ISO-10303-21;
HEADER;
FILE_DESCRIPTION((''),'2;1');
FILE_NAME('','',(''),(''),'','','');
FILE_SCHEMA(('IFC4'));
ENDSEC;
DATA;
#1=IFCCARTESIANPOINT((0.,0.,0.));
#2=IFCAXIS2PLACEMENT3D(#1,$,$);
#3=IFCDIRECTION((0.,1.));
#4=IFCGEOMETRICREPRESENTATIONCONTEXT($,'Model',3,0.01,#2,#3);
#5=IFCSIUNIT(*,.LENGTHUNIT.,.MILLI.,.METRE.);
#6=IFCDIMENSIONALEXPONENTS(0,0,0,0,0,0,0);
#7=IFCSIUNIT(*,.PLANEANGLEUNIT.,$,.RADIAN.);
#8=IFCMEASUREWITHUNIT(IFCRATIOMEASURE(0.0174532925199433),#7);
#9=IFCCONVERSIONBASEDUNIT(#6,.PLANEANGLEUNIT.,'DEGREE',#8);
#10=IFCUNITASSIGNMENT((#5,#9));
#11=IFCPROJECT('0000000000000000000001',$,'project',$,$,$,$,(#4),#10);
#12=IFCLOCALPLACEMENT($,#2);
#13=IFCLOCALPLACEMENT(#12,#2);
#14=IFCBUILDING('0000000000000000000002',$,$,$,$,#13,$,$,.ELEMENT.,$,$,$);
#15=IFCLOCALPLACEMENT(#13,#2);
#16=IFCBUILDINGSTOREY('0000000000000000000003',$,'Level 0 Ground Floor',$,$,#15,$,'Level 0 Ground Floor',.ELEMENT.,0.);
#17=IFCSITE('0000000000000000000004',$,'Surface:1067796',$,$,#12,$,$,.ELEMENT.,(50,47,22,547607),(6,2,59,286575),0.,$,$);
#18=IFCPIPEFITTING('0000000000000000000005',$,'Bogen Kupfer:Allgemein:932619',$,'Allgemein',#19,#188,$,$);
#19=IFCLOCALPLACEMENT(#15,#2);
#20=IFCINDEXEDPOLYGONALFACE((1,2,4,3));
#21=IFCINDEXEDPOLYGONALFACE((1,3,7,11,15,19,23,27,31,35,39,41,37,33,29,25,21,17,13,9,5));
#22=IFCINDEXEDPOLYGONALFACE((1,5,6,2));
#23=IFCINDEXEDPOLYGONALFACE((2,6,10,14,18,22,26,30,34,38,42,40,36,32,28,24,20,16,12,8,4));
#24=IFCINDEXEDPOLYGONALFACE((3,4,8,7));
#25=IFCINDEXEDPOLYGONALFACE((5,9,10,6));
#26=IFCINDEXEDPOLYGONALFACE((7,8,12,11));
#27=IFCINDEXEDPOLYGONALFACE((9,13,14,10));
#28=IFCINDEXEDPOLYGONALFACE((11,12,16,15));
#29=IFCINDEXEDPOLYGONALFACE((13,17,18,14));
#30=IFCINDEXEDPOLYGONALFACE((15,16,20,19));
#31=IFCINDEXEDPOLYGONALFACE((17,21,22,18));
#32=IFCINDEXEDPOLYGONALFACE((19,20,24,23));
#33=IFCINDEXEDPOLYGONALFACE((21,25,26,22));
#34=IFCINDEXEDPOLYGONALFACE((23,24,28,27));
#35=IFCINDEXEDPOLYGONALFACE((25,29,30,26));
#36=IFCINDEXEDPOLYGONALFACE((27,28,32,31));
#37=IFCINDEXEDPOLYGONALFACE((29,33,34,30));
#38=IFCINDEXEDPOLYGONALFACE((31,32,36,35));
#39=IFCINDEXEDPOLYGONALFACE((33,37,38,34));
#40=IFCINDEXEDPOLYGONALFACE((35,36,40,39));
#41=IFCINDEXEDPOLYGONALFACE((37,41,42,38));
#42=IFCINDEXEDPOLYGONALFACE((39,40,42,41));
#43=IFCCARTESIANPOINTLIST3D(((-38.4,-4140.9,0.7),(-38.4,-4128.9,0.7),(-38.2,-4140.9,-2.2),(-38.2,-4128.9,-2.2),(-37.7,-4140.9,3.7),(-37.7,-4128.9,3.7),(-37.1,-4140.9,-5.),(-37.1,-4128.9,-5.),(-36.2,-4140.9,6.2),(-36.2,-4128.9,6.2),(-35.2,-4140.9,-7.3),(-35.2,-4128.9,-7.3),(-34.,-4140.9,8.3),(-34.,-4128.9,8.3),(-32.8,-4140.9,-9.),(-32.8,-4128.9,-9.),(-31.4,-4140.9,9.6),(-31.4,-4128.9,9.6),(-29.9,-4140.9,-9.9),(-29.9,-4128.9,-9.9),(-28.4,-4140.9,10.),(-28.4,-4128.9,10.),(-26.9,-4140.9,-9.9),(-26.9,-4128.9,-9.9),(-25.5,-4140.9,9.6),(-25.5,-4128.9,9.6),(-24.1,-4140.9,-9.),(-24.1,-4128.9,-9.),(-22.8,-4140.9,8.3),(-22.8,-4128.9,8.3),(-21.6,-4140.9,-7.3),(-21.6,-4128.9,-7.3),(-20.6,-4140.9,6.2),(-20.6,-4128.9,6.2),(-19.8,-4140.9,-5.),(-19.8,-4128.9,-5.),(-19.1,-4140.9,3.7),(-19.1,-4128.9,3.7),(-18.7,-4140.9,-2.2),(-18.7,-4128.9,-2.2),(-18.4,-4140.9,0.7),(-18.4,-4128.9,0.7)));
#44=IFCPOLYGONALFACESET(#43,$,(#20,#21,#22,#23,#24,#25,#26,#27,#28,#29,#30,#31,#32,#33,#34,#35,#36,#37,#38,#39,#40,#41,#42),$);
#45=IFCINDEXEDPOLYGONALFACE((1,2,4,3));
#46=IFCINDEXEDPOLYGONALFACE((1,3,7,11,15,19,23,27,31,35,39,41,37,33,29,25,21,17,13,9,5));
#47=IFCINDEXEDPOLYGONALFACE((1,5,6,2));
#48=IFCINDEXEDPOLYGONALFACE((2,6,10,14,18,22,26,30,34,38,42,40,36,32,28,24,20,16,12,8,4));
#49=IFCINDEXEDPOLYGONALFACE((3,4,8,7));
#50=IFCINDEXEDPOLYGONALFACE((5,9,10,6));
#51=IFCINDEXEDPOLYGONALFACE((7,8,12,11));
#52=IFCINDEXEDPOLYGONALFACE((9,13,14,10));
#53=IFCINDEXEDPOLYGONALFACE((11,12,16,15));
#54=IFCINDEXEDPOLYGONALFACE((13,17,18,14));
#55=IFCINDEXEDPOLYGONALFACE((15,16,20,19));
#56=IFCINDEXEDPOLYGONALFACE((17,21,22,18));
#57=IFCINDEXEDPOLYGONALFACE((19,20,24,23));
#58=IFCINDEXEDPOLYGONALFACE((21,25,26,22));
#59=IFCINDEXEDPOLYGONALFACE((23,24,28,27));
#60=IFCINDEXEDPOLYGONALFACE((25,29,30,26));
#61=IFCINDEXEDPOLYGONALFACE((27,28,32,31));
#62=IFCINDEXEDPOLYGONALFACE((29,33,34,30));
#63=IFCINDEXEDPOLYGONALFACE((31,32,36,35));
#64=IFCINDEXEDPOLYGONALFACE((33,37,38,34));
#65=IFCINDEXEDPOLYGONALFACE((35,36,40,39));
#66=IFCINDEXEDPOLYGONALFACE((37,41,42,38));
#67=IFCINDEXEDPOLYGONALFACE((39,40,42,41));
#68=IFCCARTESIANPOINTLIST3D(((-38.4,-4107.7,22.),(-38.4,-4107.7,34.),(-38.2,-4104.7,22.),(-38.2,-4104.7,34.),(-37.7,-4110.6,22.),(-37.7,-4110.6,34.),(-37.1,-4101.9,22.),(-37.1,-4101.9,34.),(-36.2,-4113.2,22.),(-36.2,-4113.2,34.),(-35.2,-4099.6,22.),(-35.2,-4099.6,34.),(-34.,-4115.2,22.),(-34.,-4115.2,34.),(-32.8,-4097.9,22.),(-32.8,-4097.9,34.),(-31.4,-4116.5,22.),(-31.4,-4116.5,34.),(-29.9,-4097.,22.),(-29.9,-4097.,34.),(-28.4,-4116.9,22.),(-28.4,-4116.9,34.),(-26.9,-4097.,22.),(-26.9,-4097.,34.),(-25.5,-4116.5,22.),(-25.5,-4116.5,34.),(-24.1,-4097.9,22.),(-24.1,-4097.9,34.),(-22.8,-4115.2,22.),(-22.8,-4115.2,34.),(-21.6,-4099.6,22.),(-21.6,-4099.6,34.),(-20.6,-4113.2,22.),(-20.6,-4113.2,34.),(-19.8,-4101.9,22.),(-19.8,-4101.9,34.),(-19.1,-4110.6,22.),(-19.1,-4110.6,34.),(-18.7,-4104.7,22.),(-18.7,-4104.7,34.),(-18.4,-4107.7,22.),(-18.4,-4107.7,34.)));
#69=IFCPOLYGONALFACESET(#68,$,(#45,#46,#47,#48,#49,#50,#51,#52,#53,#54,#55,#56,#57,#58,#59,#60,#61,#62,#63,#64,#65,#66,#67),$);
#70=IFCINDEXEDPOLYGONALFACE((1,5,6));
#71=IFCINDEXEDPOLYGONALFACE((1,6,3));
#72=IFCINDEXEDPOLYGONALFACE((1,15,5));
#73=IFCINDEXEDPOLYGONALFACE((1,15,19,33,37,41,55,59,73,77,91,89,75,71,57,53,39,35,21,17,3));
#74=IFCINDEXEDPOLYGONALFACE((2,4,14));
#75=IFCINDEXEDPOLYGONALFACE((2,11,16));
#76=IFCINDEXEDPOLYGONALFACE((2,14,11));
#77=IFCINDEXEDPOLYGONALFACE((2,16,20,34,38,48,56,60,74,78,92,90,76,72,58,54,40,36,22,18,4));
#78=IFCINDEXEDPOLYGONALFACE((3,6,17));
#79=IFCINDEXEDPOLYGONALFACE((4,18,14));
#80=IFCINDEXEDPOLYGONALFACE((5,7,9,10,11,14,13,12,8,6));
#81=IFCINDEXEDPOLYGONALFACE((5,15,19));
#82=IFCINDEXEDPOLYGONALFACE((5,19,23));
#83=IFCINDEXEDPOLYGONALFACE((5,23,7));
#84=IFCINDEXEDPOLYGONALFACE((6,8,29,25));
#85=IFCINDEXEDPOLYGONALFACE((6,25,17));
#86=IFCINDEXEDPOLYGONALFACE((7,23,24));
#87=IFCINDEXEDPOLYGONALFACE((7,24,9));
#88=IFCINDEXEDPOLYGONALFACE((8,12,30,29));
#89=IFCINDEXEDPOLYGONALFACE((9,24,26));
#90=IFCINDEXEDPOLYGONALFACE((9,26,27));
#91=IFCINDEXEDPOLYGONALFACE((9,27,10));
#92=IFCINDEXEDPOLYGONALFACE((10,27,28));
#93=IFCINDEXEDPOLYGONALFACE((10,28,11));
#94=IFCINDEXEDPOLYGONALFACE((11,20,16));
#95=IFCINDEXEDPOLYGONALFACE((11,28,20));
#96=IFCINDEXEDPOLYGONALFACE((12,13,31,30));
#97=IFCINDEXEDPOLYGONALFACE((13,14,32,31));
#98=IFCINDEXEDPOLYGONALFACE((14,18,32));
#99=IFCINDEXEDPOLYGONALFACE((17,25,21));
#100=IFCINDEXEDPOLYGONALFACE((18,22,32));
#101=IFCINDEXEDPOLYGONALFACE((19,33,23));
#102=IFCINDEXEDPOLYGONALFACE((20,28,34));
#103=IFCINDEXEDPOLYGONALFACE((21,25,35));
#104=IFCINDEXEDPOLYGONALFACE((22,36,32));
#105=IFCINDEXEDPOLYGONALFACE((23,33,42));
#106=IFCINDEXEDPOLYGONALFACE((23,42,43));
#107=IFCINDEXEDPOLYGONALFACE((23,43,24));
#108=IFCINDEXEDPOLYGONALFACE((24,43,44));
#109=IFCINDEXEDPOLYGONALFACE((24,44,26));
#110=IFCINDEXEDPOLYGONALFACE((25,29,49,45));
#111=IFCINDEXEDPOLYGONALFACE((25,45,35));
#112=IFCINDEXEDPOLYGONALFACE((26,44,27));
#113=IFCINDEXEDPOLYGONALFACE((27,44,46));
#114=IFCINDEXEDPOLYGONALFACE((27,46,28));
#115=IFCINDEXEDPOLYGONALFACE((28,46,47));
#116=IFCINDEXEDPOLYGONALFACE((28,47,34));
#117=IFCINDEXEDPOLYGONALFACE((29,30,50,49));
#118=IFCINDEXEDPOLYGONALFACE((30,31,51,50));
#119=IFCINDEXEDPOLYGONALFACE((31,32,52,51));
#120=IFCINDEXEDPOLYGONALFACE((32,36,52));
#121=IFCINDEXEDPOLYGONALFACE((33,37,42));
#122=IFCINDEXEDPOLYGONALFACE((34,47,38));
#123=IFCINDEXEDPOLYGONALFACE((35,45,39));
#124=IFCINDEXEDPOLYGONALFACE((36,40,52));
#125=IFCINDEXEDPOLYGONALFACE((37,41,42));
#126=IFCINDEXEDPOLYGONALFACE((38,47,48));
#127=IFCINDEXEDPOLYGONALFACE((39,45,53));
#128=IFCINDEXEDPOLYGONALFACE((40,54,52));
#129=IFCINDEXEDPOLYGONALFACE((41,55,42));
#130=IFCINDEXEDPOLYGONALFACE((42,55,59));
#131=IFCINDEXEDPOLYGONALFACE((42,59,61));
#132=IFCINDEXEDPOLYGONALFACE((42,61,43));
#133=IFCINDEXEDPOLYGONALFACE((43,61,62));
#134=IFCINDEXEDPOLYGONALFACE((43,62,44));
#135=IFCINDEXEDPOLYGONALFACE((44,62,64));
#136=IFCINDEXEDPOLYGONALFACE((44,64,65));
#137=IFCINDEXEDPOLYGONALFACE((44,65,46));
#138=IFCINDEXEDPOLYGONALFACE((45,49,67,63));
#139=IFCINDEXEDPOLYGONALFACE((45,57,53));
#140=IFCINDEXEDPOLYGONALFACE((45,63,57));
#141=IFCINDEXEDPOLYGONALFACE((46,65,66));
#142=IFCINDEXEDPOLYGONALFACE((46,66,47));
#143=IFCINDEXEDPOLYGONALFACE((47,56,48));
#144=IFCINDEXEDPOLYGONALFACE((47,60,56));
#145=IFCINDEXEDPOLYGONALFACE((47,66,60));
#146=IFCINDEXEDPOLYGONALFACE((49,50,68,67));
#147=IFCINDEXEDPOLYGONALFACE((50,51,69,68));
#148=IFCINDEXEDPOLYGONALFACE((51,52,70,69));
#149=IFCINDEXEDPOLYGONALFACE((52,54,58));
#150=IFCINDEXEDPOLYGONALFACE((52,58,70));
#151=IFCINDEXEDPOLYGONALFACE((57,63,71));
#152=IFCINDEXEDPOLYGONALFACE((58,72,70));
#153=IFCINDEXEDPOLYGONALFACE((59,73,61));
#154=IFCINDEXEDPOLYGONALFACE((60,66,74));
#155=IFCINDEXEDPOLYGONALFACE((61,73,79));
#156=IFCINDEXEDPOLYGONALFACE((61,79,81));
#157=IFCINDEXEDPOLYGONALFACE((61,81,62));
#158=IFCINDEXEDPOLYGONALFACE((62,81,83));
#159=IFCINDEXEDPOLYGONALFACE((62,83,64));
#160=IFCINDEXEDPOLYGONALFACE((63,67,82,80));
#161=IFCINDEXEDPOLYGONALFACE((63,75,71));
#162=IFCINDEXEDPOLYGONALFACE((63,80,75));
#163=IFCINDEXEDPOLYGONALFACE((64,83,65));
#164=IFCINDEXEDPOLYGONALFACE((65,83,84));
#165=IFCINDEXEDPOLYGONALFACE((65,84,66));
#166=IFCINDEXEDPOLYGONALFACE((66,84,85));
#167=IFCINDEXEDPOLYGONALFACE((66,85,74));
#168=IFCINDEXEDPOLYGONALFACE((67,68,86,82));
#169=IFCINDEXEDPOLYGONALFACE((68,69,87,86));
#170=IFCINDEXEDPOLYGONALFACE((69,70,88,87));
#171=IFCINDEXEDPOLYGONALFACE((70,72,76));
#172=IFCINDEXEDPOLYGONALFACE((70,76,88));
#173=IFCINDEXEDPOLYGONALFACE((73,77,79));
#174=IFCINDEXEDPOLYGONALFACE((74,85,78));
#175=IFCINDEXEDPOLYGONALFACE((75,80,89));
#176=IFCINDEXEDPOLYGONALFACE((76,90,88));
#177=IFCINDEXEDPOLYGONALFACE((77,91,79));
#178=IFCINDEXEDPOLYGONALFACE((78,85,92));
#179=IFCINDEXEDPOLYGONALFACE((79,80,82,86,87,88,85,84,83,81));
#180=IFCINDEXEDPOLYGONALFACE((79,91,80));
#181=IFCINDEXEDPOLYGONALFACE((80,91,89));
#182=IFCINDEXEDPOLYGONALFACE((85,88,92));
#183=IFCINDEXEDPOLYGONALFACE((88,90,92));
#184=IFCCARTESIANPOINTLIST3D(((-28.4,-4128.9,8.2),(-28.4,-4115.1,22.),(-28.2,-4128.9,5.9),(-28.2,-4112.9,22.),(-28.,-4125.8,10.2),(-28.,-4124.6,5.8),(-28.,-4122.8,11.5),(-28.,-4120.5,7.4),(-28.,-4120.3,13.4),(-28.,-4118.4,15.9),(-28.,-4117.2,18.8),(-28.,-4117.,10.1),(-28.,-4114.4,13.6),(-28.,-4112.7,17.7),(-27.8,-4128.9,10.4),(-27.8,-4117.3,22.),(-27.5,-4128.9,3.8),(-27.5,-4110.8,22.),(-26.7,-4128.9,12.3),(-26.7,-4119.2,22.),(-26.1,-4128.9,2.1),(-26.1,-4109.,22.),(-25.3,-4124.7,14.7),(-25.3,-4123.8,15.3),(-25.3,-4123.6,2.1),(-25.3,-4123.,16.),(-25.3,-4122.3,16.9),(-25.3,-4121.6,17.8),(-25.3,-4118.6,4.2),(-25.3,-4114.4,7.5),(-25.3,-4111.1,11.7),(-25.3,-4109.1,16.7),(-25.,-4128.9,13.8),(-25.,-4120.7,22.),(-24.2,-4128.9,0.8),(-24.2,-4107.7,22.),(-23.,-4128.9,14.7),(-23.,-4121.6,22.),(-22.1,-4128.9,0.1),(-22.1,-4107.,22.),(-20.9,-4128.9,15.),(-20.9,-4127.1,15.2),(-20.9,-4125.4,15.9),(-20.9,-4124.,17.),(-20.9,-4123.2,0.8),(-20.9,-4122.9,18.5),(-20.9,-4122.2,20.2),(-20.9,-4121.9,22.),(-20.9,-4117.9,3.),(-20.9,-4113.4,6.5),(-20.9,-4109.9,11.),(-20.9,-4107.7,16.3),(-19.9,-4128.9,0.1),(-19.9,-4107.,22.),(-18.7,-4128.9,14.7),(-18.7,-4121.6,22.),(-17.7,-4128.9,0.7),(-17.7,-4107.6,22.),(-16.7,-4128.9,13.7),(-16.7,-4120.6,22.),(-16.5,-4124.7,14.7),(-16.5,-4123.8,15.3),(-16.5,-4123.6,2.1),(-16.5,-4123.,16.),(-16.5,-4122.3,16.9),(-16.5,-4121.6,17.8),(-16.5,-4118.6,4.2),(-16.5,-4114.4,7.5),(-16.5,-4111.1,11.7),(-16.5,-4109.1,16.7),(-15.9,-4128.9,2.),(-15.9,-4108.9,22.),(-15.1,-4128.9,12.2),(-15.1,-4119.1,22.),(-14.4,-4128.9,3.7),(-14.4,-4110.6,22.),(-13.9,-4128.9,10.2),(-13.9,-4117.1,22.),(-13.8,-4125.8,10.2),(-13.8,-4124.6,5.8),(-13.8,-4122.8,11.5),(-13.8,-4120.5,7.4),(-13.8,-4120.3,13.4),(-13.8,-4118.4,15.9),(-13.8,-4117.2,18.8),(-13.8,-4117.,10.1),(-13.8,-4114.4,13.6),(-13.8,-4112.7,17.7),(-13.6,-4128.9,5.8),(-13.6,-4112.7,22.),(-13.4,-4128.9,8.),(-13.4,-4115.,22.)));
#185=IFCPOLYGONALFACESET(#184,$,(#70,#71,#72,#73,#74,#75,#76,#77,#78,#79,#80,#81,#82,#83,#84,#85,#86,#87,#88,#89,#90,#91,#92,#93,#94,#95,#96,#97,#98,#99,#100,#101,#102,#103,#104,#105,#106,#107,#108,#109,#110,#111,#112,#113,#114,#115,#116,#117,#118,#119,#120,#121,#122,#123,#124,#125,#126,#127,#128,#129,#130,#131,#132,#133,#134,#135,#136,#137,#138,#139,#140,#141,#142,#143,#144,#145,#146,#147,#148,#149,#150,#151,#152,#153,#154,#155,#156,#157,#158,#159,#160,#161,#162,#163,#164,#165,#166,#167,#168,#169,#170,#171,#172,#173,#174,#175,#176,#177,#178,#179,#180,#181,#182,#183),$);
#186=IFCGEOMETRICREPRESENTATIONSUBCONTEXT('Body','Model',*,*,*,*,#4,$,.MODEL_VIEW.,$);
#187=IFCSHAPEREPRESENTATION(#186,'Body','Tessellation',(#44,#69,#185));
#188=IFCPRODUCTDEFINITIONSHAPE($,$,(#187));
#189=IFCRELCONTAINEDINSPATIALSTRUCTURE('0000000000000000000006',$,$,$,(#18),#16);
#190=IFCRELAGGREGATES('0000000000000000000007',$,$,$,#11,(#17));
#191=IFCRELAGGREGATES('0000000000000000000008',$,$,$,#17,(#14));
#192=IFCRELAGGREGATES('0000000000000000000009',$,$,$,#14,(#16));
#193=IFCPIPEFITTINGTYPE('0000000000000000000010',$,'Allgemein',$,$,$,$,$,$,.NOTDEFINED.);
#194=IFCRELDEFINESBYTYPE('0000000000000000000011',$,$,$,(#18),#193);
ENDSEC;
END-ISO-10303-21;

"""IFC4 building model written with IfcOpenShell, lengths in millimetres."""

from ifc_helpers import new_model, entity, si_unit, converted_unit, direction, frame, frame_2d, origin, place, context, subcontext, project, spatial, circle, extrude, source, transform, mapped, type_object, type_shapes, element, save


model = new_model("IFC4")

# Units and contexts
model_context = context("Model", 3, precision=0.01, world=origin(), true_north=direction((0.0, 1.0)))
body_context = subcontext(model_context, "Body", "Model", "MODEL_VIEW")
ifc_project = project(units=[si_unit("LENGTHUNIT", "METRE", prefix="MILLI"), converted_unit("PLANEANGLEUNIT", "DEGREE", entity("IfcRatioMeasure", 0.0174532925199433), si_unit("PLANEANGLEUNIT", "RADIAN"), dimensions=[0, 0, 0, 0, 0, 0, 0])], contexts=[model_context])

# Site, building, storey
site_placement = place(None, origin())
site = spatial("IfcSite", under=ifc_project, at=site_placement, Name="Surface:1067796", CompositionType="ELEMENT", RefLatitude=(50, 47, 22, 547607), RefLongitude=(6, 2, 59, 286575), RefElevation=0.0)
building_placement = place(site_placement, origin())
building = spatial("IfcBuilding", under=site, at=building_placement, CompositionType="ELEMENT")
storey_placement = place(building_placement, origin())
storey = spatial("IfcBuildingStorey", under=building, at=storey_placement, Name="Level 0 Ground Floor", LongName="Level 0 Ground Floor", CompositionType="ELEMENT", Elevation=0.0)

# Pipe fitting
pipe_fitting_type_1 = type_object("IfcPipeFittingType", Name="Allgemein", PredefinedType="NOTDEFINED")
ifc_direction = entity("IfcDirection", [0.0, 0.0, -1.0])
trimmed_curve = entity("IfcTrimmedCurve", entity("IfcCircle", entity("IfcAxis2Placement2D", entity("IfcCartesianPoint", [-14.5, 0.0]), entity("IfcDirection", [0.0, 1.0])), 14.5), [entity("IfcParameterValue", 270.0)], [entity("IfcParameterValue", 0.0)], True, "PARAMETER")
shared_shape_1 = source(origin(), body_context, "Body", "SolidModel", [
    extrude(circle(Radius=10.0, at=frame_2d((0.0, 0.0), x_axis=(1.0, 0.0))), frame((0.0, 22.0, 0.0), z_axis=(0.0, 1.0, 0.0), x_axis=(-1.0, 0.0, 0.0)), (0.0, 0.0, 1.0), 12.0),
    extrude(circle(Radius=10.0, at=frame_2d((0.0, 0.0), x_axis=(1.0, 0.0))), frame((-34.0, 0.0, 0.0), z_axis=(1.0, 0.0, 0.0), x_axis=(0.0, 1.0, 0.0)), (0.0, 0.0, 1.0), 12.0),
    entity("IfcSurfaceCurveSweptAreaSolid", entity("IfcCircleProfileDef", "AREA", None, entity("IfcAxis2Placement2D", entity("IfcCartesianPoint", [0.0, 7.5]), entity("IfcDirection", [1.0, 0.0])), 7.5), entity("IfcAxis2Placement3D", entity("IfcCartesianPoint", [-7.5, 22.0, 0.0]), ifc_direction, entity("IfcDirection", [1.0, 0.0, 0.0])), trimmed_curve, 0.0, 90.0, entity("IfcSurfaceOfLinearExtrusion", entity("IfcArbitraryOpenProfileDef", "CURVE", None, trimmed_curve), entity("IfcAxis2Placement3D", entity("IfcCartesianPoint", [0.0, 0.0, -304.8])), ifc_direction, 1.0)),
])
type_shapes(pipe_fitting_type_1, [shared_shape_1])
for number, where, z_axis, x_axis, name in (
    (1, (-28.4, -4106.9, 0.0), (-1.0, 0.0, 0.0), (0.0, 0.0, -1.0), "Bogen Kupfer:Allgemein:932619"),
):
    element("IfcPipeFitting", number, at=place(storey_placement, frame(where, z_axis=z_axis, x_axis=x_axis)), inside=storey, type_object=pipe_fitting_type_1, Name=name, ObjectType="Allgemein", context=body_context, shape_type="MappedRepresentation", body=[
        mapped(shared_shape_1, transform((0.0, 0.0, 0.0), scale=1.0)),
    ])

save(model, "model.ifc")
